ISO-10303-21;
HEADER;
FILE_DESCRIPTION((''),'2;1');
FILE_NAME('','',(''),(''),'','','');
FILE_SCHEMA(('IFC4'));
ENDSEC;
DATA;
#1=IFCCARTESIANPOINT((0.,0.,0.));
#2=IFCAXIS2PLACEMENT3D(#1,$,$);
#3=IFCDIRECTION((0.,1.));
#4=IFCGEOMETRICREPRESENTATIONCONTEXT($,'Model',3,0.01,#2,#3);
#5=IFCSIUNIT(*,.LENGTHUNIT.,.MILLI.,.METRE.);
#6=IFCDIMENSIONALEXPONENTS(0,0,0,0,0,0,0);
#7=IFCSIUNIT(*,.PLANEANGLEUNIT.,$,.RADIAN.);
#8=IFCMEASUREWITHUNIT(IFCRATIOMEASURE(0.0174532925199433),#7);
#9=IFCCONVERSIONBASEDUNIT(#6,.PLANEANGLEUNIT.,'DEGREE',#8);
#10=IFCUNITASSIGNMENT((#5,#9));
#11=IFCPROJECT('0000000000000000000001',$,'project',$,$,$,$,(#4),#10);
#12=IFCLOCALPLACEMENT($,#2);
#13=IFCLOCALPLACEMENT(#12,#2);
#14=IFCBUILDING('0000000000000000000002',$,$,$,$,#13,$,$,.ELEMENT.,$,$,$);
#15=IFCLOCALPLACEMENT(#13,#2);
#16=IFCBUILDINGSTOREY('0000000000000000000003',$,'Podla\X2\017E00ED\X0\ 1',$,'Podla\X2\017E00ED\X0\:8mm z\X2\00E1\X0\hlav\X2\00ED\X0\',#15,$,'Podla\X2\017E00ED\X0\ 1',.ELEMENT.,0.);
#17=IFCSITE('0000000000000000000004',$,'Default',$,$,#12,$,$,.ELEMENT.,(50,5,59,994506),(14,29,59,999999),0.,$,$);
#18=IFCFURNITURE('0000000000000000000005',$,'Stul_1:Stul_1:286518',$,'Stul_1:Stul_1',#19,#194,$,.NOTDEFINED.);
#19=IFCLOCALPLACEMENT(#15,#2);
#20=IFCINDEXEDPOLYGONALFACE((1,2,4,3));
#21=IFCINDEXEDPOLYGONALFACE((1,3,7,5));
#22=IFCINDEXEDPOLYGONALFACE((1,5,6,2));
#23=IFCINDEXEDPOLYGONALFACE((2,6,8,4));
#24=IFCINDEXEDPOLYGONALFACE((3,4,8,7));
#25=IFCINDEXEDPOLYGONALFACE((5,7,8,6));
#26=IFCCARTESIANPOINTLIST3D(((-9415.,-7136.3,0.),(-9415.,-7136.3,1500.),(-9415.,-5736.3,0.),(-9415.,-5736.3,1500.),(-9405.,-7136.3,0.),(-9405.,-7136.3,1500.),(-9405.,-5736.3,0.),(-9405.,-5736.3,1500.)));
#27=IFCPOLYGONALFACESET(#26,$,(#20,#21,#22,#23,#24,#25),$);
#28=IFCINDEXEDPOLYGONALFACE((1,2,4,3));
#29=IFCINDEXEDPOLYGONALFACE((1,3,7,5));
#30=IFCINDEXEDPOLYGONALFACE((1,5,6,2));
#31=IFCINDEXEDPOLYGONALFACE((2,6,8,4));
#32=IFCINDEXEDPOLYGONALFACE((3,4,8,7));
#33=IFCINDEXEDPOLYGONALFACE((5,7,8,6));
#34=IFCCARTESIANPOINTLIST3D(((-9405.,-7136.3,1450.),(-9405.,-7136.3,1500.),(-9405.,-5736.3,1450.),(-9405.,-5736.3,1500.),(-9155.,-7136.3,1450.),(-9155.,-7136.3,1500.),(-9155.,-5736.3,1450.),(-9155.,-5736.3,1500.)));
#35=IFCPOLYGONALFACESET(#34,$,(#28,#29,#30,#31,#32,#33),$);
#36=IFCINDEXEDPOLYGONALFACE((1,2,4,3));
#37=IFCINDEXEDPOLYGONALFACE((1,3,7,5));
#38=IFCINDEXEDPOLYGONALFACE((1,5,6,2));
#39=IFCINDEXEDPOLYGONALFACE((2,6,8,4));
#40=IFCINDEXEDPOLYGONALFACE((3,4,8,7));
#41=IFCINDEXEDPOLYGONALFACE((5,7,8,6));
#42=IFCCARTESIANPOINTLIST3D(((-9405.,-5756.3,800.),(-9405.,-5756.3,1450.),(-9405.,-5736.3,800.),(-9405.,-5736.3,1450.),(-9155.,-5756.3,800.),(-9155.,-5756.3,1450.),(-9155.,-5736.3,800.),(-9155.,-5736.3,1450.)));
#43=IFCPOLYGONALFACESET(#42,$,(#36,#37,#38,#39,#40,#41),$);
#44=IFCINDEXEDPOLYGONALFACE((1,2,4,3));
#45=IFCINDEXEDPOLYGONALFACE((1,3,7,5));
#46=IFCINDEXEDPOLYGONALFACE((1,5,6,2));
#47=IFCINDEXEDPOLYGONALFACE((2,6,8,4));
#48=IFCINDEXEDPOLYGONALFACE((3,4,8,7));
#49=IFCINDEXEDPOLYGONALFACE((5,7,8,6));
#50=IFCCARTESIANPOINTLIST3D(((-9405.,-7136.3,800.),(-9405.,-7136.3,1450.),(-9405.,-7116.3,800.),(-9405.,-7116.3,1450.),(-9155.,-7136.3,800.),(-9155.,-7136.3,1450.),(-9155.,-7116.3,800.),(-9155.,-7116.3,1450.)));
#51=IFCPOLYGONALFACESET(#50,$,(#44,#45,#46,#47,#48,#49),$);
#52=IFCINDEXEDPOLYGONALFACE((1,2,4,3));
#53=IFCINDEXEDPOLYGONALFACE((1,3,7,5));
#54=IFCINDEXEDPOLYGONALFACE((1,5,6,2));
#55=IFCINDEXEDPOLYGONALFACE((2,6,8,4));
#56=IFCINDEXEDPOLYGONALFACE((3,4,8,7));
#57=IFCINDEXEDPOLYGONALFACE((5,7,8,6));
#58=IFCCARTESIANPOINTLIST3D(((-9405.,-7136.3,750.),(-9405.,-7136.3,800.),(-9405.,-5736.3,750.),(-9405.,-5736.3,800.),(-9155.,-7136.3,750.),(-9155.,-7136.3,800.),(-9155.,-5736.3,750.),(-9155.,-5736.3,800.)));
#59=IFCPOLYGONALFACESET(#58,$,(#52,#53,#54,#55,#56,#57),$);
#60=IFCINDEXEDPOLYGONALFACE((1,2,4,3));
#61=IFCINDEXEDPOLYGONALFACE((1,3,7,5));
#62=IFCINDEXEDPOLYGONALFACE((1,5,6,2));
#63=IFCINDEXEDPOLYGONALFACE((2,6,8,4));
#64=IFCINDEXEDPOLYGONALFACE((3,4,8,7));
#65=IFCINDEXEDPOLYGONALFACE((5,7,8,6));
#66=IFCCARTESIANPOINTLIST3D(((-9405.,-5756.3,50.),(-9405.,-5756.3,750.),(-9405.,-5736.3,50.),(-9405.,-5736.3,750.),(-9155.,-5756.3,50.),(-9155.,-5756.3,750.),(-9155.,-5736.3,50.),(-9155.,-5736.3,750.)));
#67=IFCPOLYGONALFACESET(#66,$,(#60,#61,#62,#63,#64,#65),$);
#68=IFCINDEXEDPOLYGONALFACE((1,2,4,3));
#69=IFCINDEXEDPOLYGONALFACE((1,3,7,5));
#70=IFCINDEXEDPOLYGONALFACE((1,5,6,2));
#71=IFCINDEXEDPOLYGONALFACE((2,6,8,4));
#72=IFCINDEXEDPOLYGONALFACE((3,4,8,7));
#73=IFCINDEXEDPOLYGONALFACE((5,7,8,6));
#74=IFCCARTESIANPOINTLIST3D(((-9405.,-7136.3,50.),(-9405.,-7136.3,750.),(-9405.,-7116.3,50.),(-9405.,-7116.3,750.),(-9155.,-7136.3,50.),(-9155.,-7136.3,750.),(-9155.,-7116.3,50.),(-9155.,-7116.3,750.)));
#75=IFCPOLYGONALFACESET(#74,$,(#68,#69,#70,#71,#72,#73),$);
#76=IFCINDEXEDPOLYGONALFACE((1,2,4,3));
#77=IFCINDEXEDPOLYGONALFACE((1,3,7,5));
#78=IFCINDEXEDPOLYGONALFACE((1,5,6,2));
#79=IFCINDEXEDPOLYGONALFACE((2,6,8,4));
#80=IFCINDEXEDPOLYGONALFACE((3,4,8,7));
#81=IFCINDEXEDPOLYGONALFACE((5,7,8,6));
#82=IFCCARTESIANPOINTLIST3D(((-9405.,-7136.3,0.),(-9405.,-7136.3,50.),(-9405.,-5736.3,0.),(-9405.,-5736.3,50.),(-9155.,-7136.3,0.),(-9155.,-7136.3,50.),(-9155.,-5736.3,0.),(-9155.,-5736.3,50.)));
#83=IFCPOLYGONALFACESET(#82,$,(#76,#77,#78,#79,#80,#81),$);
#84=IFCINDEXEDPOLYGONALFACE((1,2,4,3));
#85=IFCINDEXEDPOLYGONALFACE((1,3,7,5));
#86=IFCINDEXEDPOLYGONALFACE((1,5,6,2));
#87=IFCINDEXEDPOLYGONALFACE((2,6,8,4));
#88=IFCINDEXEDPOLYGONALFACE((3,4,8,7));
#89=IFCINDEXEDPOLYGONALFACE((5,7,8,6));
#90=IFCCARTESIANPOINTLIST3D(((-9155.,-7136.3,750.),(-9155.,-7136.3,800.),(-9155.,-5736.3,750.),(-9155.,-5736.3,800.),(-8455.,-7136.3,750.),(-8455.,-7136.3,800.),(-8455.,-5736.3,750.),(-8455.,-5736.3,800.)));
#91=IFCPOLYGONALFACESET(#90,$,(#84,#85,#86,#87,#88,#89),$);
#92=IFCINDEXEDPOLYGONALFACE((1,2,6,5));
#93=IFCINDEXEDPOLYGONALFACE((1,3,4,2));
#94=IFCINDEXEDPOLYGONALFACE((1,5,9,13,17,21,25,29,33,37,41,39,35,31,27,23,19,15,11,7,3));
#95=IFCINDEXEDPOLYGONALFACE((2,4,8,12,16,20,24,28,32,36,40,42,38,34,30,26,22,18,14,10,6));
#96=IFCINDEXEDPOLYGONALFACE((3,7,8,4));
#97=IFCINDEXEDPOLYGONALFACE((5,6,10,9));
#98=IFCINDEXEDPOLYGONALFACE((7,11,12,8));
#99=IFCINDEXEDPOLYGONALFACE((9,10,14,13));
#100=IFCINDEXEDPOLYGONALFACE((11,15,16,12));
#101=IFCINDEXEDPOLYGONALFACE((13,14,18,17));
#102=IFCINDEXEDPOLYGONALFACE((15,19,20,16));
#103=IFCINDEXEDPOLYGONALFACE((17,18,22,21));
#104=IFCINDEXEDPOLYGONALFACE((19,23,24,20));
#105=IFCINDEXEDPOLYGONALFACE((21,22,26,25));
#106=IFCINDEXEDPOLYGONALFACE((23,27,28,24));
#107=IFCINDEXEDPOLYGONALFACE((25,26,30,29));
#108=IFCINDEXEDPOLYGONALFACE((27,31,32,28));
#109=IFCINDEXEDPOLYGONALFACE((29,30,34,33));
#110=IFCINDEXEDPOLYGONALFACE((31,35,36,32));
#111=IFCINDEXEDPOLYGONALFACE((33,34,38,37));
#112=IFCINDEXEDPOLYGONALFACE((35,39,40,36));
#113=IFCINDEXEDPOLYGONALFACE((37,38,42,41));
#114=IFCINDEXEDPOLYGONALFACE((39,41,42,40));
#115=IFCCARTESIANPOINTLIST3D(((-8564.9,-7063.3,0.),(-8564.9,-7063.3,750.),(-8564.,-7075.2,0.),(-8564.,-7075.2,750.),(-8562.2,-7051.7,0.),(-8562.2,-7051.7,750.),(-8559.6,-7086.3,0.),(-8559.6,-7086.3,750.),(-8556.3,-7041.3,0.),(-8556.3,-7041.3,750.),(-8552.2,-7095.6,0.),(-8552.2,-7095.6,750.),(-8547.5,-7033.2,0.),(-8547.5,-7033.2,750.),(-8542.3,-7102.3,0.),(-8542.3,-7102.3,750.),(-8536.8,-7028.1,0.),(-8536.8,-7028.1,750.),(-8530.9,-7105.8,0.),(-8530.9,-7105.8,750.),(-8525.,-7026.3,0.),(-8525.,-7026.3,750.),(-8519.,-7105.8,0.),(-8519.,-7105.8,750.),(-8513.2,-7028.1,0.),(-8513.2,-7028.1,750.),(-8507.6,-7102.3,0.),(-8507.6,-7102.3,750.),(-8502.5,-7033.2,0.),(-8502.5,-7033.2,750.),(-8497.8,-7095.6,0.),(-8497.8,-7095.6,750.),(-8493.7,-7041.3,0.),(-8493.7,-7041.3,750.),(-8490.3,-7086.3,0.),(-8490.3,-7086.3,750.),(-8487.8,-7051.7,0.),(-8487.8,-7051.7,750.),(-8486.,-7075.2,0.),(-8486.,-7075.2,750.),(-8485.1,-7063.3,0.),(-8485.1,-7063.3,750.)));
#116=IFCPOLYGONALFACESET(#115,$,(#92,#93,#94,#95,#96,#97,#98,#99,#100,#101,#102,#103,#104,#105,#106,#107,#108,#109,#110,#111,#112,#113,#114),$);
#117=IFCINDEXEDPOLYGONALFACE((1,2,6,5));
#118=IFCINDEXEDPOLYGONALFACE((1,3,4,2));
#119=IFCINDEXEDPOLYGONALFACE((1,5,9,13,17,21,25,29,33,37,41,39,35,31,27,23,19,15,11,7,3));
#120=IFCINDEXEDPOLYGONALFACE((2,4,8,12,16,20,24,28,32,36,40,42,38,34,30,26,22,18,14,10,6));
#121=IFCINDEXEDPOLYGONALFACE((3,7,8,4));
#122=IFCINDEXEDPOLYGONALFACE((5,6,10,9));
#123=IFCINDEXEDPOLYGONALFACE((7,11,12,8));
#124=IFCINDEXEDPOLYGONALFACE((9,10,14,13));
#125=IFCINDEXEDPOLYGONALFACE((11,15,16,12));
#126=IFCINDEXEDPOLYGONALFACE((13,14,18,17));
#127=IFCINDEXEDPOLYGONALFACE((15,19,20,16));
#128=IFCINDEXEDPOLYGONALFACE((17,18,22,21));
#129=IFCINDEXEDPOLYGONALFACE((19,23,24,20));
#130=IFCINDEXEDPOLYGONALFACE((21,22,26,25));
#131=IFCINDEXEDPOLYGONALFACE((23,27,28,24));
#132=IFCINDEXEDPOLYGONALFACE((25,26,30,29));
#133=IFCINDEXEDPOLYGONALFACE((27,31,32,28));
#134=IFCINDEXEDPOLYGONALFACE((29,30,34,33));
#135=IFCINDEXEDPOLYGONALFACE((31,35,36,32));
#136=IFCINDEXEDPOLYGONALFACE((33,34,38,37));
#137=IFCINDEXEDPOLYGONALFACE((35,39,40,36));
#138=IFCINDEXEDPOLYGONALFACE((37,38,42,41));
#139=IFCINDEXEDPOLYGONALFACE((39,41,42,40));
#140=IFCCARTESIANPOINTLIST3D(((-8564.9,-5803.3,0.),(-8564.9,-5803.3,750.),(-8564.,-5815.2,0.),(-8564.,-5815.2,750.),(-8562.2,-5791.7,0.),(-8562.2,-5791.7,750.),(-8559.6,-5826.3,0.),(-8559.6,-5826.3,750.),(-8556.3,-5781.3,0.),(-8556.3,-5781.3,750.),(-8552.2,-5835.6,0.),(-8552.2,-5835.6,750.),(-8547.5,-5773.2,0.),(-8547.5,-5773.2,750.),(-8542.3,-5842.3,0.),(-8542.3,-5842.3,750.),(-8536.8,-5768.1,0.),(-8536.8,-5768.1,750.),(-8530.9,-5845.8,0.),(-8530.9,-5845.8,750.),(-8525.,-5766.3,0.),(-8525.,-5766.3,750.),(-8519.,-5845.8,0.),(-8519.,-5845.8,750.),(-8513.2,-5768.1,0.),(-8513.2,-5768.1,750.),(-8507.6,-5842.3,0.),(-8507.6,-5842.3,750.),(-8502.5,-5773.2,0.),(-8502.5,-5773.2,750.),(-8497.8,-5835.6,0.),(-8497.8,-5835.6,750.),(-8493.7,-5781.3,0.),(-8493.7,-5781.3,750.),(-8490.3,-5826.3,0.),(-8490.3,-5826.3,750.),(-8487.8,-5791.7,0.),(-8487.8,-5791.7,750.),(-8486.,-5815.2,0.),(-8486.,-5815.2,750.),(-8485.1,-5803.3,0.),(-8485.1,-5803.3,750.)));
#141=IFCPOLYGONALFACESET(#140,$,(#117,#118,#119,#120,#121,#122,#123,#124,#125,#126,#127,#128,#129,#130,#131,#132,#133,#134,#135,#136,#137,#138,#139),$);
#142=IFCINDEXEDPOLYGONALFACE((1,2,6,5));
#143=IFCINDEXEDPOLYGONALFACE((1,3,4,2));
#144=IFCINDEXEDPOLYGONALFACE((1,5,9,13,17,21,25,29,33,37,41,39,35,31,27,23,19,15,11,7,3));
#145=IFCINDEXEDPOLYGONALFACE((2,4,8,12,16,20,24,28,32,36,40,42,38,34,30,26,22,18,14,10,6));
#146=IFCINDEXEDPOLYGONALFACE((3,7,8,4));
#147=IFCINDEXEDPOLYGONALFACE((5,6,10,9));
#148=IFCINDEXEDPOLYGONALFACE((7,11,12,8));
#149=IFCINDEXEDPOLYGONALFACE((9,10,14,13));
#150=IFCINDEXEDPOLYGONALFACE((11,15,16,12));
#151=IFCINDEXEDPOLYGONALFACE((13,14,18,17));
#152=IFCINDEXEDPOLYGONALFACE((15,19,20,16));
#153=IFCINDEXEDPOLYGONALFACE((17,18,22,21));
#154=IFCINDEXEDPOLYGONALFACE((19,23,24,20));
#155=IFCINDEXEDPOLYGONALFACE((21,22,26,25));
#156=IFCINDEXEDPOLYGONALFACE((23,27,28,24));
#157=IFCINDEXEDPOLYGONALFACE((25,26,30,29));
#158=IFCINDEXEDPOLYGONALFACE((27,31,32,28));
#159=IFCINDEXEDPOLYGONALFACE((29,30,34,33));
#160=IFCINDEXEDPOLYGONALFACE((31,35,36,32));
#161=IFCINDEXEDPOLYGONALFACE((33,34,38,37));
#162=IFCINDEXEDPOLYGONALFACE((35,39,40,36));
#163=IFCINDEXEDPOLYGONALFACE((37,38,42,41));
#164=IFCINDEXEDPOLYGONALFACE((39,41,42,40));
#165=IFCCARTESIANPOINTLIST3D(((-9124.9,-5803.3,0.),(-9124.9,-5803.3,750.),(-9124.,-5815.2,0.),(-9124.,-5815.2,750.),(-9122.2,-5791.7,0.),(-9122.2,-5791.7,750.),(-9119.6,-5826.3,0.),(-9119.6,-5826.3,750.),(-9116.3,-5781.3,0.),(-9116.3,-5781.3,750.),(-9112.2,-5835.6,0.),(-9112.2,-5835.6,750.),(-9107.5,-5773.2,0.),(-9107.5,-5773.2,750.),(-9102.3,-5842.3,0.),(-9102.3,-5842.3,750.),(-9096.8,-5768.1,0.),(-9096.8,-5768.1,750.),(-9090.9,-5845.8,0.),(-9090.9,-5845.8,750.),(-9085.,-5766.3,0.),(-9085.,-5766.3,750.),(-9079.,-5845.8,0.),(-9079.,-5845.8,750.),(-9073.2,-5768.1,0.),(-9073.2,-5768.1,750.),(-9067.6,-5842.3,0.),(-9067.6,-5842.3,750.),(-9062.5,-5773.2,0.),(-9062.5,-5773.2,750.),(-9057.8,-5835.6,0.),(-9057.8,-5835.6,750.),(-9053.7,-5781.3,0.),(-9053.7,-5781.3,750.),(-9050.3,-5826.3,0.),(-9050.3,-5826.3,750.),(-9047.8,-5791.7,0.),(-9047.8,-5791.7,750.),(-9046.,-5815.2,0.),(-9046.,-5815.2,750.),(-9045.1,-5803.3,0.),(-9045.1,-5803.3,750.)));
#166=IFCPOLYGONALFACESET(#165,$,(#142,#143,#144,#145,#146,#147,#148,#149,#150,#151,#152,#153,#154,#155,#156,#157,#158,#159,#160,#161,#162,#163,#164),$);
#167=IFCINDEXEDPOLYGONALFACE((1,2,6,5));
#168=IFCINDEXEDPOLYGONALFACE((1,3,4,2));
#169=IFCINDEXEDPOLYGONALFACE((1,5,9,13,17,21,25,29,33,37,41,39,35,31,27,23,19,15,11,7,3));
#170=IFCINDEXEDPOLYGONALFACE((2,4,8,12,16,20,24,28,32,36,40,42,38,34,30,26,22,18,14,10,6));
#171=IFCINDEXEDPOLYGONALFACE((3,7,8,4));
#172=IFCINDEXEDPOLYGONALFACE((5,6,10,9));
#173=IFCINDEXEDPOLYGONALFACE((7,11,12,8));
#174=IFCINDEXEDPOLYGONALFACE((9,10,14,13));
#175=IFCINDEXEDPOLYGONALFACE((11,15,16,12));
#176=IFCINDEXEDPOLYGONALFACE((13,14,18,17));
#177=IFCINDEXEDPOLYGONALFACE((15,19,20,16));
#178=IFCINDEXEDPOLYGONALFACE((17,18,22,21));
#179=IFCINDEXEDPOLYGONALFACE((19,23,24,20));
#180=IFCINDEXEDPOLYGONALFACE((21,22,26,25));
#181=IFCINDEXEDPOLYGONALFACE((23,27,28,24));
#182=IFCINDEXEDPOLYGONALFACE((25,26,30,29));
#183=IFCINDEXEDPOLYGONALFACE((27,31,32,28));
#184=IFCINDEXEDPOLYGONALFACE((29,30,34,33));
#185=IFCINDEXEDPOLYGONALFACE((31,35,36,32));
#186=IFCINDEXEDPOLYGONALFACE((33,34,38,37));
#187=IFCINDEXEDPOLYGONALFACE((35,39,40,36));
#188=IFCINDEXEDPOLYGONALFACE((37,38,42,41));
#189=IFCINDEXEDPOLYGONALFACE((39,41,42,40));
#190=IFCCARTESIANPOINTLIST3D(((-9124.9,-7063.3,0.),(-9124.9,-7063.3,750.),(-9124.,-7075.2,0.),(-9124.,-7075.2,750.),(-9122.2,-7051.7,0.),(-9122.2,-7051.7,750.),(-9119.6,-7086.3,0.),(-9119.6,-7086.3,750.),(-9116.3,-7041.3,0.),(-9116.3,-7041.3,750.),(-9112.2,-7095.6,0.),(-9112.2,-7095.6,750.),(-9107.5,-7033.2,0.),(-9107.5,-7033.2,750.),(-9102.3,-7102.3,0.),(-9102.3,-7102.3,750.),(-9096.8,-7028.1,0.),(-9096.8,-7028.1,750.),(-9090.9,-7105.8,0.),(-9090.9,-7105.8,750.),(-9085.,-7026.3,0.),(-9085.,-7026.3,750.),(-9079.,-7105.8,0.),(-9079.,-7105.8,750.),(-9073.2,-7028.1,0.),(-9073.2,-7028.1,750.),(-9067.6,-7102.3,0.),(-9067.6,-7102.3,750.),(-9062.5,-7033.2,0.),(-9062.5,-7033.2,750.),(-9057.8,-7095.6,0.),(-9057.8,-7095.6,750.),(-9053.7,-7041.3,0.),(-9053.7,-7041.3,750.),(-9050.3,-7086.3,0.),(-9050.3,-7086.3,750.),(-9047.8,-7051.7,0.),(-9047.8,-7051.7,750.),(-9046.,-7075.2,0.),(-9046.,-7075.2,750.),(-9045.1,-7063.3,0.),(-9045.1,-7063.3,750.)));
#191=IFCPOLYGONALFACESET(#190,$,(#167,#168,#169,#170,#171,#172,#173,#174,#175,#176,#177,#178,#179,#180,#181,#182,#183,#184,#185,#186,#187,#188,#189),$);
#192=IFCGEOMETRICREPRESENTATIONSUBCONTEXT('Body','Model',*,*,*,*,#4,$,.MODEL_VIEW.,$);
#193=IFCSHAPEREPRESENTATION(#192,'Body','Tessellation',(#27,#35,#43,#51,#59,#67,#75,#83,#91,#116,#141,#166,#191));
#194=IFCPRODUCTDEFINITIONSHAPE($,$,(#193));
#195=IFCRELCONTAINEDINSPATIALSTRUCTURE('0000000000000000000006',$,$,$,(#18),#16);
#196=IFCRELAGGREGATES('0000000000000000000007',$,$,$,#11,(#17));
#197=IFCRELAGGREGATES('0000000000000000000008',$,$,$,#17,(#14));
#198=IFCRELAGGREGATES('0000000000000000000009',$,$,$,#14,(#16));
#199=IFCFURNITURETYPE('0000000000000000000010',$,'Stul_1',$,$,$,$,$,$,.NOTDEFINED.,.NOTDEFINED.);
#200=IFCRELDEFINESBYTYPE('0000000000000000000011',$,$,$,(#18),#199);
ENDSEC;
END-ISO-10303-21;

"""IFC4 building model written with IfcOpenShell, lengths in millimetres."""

from ifc_helpers import new_model, entity, si_unit, converted_unit, direction, frame, frame_2d, origin, origin_2d_with_axis, place, context, subcontext, project, spatial, rectangle, circle, extrude, source, transform, mapped, type_object, type_shapes, element, save


model = new_model("IFC4")

# Units and contexts
model_context = context("Model", 3, precision=0.01, world=origin(), true_north=direction((0.0, 1.0)))
body_context = subcontext(model_context, "Body", "Model", "MODEL_VIEW")
ifc_project = project(units=[si_unit("LENGTHUNIT", "METRE", prefix="MILLI"), converted_unit("PLANEANGLEUNIT", "DEGREE", entity("IfcRatioMeasure", 0.0174532925199433), si_unit("PLANEANGLEUNIT", "RADIAN"), dimensions=[0, 0, 0, 0, 0, 0, 0])], contexts=[model_context])

# Site, building, storey
site_placement = place(None, origin())
site = spatial("IfcSite", under=ifc_project, at=site_placement, Name="Default", CompositionType="ELEMENT", RefLatitude=(50, 5, 59, 994506), RefLongitude=(14, 29, 59, 999999), RefElevation=0.0)
building_placement = place(site_placement, origin())
building = spatial("IfcBuilding", under=site, at=building_placement, CompositionType="ELEMENT")
storey_placement = place(building_placement, origin())
storey = spatial("IfcBuildingStorey", under=building, at=storey_placement, Name="Podlaží 1", ObjectType="Podlaží:8mm záhlaví", LongName="Podlaží 1", CompositionType="ELEMENT", Elevation=0.0)

# Furniture
furniture_type = type_object("IfcFurnitureType", Name="Stul_1", AssemblyPlace="NOTDEFINED", PredefinedType="NOTDEFINED")
shared_shape_1 = source(origin(), body_context, "Body", "SweptSolid", [
    extrude(rectangle(XDim=1400.0, YDim=10.0, at=origin_2d_with_axis()), frame((0.0, 605.0, 0.0), z_axis=(0.0, 0.0, 1.0), x_axis=(-1.0, 0.0, 0.0)), (0.0, 0.0, 1.0), 1500.0),
    extrude(rectangle(XDim=1400.0, YDim=250.0, at=frame_2d((0.0, 0.0), x_axis=(1.0, 0.0))), frame((0.0, 475.0, 1450.0), z_axis=(0.0, 0.0, 1.0), x_axis=(-1.0, 0.0, 0.0)), (0.0, 0.0, 1.0), 50.0),
    extrude(rectangle(XDim=20.0, YDim=250.0, at=origin_2d_with_axis()), frame((690.0, 475.0, 800.0), z_axis=(0.0, 0.0, 1.0), x_axis=(-1.0, 0.0, 0.0)), (0.0, 0.0, 1.0), 650.0),
    extrude(rectangle(XDim=20.0, YDim=250.0, at=frame_2d((0.0, 0.0), x_axis=(1.0, 0.0))), frame((-690.0, 475.0, 800.0), z_axis=(0.0, 0.0, 1.0), x_axis=(-1.0, 0.0, 0.0)), (0.0, 0.0, 1.0), 650.0),
    extrude(rectangle(XDim=1400.0, YDim=250.0, at=origin_2d_with_axis()), frame((0.0, 475.0, 750.0), z_axis=(0.0, 0.0, 1.0), x_axis=(-1.0, 0.0, 0.0)), (0.0, 0.0, 1.0), 50.0),
    extrude(rectangle(XDim=20.0, YDim=250.0, at=origin_2d_with_axis()), frame((690.0, 475.0, 50.0), z_axis=(0.0, 0.0, 1.0), x_axis=(-1.0, 0.0, 0.0)), (0.0, 0.0, 1.0), 700.0),
    extrude(rectangle(XDim=20.0, YDim=250.0, at=frame_2d((0.0, 0.0), x_axis=(1.0, 0.0))), frame((-690.0, 475.0, 50.0), z_axis=(0.0, 0.0, 1.0), x_axis=(-1.0, 0.0, 0.0)), (0.0, 0.0, 1.0), 700.0),
    extrude(rectangle(XDim=1400.0, YDim=250.0, at=origin_2d_with_axis()), frame((0.0, 475.0, 0.0), z_axis=(0.0, 0.0, 1.0), x_axis=(-1.0, 0.0, 0.0)), (0.0, 0.0, 1.0), 50.0),
    extrude(rectangle(XDim=1400.0, YDim=700.0, at=origin_2d_with_axis()), frame((0.0, 0.0, 750.0), z_axis=(0.0, 0.0, 1.0), x_axis=(-1.0, 0.0, 0.0)), (0.0, 0.0, 1.0), 50.0),
    extrude(circle(Radius=40.0, at=frame_2d((0.0, 0.0), x_axis=(1.0, 0.0))), frame((-630.0, -280.0, 0.0)), (0.0, 0.0, 1.0), 750.0),
    extrude(circle(Radius=40.0, at=frame_2d((0.0, 0.0), x_axis=(1.0, 0.0))), frame((630.0, -280.0, 0.0)), (0.0, 0.0, 1.0), 750.0),
    extrude(circle(Radius=40.0, at=frame_2d((0.0, 0.0), x_axis=(1.0, 0.0))), frame((630.0, 280.0, 0.0)), (0.0, 0.0, 1.0), 750.0),
    extrude(circle(Radius=40.0, at=frame_2d((0.0, 0.0), x_axis=(1.0, 0.0))), frame((-630.0, 280.0, 0.0)), (0.0, 0.0, 1.0), 750.0),
])
type_shapes(furniture_type, [shared_shape_1])
for number, where, z_axis, x_axis, name in (
    (1, (-8805.0, -6436.3, 0.0), (0.0, 0.0, 1.0), (0.0, 1.0, 0.0), "Stul_1:Stul_1:286518"),
):
    element("IfcFurniture", number, at=place(storey_placement, frame(where, z_axis=z_axis, x_axis=x_axis)), inside=storey, type_object=furniture_type, Name=name, ObjectType="Stul_1:Stul_1", PredefinedType="NOTDEFINED", context=body_context, shape_type="MappedRepresentation", body=[
        mapped(shared_shape_1, transform((0.0, 0.0, 0.0), scale=1.0)),
    ])

save(model, "model.ifc")
